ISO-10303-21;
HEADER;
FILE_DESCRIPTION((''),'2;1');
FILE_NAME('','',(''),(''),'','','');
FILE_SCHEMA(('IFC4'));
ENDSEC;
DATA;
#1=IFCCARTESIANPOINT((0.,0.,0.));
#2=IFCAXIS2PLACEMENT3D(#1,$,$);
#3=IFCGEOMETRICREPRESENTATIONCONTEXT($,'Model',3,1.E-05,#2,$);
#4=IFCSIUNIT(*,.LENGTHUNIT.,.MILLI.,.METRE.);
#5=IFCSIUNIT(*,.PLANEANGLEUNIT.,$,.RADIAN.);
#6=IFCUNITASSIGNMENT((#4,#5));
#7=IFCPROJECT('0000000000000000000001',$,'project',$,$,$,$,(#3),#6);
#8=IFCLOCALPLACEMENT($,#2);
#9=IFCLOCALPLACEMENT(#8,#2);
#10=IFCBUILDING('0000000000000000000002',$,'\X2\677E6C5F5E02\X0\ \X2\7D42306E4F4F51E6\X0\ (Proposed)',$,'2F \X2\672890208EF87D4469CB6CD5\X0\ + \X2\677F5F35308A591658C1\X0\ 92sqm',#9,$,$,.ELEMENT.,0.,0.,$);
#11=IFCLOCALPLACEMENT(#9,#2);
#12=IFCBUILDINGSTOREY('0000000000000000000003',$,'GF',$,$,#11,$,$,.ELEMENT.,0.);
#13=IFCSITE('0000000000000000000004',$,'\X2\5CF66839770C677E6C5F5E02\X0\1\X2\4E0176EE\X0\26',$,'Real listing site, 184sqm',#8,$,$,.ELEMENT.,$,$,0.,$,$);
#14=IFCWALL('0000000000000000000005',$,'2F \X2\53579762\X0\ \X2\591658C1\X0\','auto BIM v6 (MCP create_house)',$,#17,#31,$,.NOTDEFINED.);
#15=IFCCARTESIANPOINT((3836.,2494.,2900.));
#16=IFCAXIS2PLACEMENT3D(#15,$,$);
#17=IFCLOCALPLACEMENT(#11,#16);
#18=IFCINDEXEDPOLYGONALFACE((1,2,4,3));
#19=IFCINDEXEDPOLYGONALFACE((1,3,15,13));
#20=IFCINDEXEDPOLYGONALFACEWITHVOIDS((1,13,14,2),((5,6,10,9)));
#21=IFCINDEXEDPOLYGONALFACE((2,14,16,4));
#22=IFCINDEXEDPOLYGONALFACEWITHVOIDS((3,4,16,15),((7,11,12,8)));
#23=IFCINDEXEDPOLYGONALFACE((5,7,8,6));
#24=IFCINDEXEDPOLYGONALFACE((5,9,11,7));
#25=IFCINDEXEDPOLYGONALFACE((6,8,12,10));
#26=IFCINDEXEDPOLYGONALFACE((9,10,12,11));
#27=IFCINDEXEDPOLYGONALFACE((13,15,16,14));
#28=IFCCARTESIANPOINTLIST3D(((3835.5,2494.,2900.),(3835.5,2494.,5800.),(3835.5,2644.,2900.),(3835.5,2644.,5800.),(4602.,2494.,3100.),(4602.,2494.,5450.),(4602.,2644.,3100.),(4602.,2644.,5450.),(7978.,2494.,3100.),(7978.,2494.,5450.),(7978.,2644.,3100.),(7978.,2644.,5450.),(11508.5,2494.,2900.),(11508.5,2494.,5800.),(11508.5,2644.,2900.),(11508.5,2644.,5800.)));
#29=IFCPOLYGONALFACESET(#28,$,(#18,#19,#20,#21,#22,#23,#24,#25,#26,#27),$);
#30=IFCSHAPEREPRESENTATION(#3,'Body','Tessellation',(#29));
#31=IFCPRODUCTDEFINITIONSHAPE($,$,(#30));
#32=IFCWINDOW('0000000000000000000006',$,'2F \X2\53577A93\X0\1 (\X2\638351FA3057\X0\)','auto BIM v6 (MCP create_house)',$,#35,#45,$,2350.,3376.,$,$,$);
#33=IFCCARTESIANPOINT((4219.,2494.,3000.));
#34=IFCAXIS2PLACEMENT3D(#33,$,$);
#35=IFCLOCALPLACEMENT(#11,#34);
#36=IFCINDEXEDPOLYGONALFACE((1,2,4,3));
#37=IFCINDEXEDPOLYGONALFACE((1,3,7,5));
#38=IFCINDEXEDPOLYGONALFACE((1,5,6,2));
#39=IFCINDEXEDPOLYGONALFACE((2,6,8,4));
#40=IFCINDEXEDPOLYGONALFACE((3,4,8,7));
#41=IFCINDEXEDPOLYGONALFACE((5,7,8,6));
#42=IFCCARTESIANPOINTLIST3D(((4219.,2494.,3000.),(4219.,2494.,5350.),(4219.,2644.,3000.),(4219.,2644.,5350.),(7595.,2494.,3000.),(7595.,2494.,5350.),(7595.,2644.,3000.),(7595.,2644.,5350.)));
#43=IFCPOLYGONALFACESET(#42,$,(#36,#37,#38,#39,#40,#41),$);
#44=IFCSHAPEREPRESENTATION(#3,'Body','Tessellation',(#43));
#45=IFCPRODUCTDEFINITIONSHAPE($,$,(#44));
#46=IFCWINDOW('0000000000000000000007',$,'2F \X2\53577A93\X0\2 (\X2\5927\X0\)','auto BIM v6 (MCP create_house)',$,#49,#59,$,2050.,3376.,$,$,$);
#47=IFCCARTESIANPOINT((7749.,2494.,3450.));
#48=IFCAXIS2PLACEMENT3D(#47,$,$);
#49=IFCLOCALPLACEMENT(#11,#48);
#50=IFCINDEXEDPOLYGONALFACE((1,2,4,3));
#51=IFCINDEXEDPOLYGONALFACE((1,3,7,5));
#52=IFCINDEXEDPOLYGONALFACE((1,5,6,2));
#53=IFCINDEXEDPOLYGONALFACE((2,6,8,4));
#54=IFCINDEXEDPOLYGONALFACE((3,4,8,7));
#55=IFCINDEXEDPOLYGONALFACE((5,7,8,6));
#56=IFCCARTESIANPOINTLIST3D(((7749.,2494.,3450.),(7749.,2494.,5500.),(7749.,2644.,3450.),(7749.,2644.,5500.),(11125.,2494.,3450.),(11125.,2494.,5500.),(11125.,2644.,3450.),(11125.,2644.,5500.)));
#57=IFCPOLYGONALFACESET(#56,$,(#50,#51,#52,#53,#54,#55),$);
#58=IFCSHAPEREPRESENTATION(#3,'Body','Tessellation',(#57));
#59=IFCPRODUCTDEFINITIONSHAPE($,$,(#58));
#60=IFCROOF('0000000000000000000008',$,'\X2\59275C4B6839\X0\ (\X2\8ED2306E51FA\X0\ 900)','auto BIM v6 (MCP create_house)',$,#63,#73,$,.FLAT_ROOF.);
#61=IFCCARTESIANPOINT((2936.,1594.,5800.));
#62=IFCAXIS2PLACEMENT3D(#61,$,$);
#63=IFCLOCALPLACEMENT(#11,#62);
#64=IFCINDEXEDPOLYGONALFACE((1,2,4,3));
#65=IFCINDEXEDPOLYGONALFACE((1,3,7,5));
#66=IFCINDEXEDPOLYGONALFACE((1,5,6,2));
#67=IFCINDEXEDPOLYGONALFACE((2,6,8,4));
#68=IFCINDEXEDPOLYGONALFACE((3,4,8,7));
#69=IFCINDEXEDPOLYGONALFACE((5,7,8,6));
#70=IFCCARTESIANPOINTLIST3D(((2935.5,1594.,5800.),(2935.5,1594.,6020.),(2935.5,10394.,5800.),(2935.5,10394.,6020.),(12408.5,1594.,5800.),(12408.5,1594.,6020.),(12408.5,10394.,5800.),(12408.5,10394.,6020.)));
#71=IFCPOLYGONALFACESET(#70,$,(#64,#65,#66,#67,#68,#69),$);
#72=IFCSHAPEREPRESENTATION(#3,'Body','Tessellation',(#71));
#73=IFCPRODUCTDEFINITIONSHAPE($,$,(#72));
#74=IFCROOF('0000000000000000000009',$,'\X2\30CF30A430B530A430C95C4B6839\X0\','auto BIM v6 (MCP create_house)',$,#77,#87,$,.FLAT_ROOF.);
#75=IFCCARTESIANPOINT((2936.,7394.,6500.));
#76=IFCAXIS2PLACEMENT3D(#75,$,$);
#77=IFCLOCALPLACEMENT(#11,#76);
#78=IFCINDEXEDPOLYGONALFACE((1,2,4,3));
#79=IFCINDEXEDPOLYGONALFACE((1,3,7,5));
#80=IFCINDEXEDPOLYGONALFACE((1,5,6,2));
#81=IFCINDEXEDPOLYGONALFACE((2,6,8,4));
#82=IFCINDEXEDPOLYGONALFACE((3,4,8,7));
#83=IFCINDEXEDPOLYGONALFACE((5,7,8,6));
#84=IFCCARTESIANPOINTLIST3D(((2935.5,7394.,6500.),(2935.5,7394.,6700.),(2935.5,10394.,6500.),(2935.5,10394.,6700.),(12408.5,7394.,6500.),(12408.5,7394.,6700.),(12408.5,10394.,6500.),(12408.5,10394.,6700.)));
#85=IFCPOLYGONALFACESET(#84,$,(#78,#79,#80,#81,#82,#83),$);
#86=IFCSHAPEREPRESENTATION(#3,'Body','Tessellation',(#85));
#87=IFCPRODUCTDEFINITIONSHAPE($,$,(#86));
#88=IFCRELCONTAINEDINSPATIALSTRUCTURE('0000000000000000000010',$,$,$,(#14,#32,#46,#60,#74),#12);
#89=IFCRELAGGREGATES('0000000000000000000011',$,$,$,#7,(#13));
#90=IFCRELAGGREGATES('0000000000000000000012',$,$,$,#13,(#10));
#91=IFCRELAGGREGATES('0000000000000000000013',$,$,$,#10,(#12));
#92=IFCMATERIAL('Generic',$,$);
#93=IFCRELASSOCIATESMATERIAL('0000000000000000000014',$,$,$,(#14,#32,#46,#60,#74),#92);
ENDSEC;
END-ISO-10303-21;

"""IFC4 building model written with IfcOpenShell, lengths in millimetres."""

from ifc_helpers import new_model, si_unit, frame, frame_2d, origin, place, context, project, spatial, rectangle, extrude, material, element, fill, save


model = new_model("IFC4")

# Units and contexts
model_context = context("Model", 3, precision=1e-05, world=origin())
ifc_project = project(units=[si_unit("LENGTHUNIT", "METRE", prefix="MILLI"), si_unit("PLANEANGLEUNIT", "RADIAN")], contexts=[model_context])

# Site, building, storey
site_placement = place(None, origin())
site = spatial("IfcSite", under=ifc_project, at=site_placement, Name="島根県松江市1丁目26", ObjectType="Real listing site, 184sqm", CompositionType="ELEMENT", RefElevation=0.0)
building_placement = place(site_placement, origin())
building = spatial("IfcBuilding", under=site, at=building_placement, Name="松江市 終の住処 (Proposed)", ObjectType="2F 木造軸組構法 + 板張り外壁 92sqm", CompositionType="ELEMENT", ElevationOfRefHeight=0.0, ElevationOfTerrain=0.0)
storey_placement = place(building_placement, origin())
storey = spatial("IfcBuildingStorey", under=building, at=storey_placement, Name="GF", CompositionType="ELEMENT", Elevation=0.0)

# Shared definitions
ifc_material = material(Name="Generic")

# Wall, openings, windows
wall_1_placement = place(storey_placement, frame((3836.0, 2494.0, 2900.0)))
wall_1 = element("IfcWall", 1, at=wall_1_placement, inside=storey, material=ifc_material, Name="2F 南面 外壁", Description="auto BIM v6 (MCP create_house)", PredefinedType="NOTDEFINED", context=model_context, shape_type="SweptSolid", body=[
    extrude(rectangle(XDim=7673.0, YDim=150.0, at=frame_2d((3836.0, 75.0))), frame((3836.0, 2494.0, 2900.0)), (0.0, 0.0, 1.0), 2900.0),
])
opening_1_placement = place(storey_placement, frame((4219.0, 2494.0, 3000.0)))
opening_1 = element("IfcOpeningElement", 2, at=opening_1_placement, cuts=wall_1, PredefinedType="NOTDEFINED", context=model_context, shape_type="SweptSolid", body=[
    extrude(rectangle(XDim=3376.0, YDim=150.0, at=frame_2d((1688.0, 75.0))), frame((4219.0, 2494.0, 3000.0)), (0.0, 0.0, 1.0), 2350.0),
])
opening_2_placement = place(storey_placement, frame((7749.0, 2494.0, 3450.0)))
opening_2 = element("IfcOpeningElement", 3, at=opening_2_placement, cuts=wall_1, PredefinedType="NOTDEFINED", context=model_context, shape_type="SweptSolid", body=[
    extrude(rectangle(XDim=3376.0, YDim=150.0, at=frame_2d((1688.0, 75.0))), frame((7749.0, 2494.0, 3450.0)), (0.0, 0.0, 1.0), 2050.0),
])
window_1_placement = place(storey_placement, frame((4219.0, 2494.0, 3000.0)))
window_1 = element("IfcWindow", 4, at=window_1_placement, inside=storey, material=ifc_material, Name="2F 南窓1 (掃出し)", Description="auto BIM v6 (MCP create_house)", OverallHeight=2350.0, OverallWidth=3376.0, context=model_context, shape_type="SweptSolid", body=[
    extrude(rectangle(XDim=3376.0, YDim=150.0, at=frame_2d((1688.0, 75.0))), frame((4219.0, 2494.0, 3000.0)), (0.0, 0.0, 1.0), 2350.0),
])
fill(opening_1, window_1)
window_2_placement = place(storey_placement, frame((7749.0, 2494.0, 3450.0)))
window_2 = element("IfcWindow", 5, at=window_2_placement, inside=storey, material=ifc_material, Name="2F 南窓2 (大)", Description="auto BIM v6 (MCP create_house)", OverallHeight=2050.0, OverallWidth=3376.0, context=model_context, shape_type="SweptSolid", body=[
    extrude(rectangle(XDim=3376.0, YDim=150.0, at=frame_2d((1688.0, 75.0))), frame((7749.0, 2494.0, 3450.0)), (0.0, 0.0, 1.0), 2050.0),
])
fill(opening_2, window_2)

# Roofs
roof_1_placement = place(storey_placement, frame((2936.0, 1594.0, 5800.0)))
element("IfcRoof", 6, at=roof_1_placement, inside=storey, material=ifc_material, Name="大屋根 (軒の出 900)", Description="auto BIM v6 (MCP create_house)", PredefinedType="FLAT_ROOF", context=model_context, shape_type="SweptSolid", body=[
    extrude(rectangle(XDim=9473.0, YDim=8800.0, at=frame_2d((4736.0, 4400.0))), frame((2936.0, 1594.0, 5800.0)), (0.0, 0.0, 1.0), 220.0),
])
roof_2_placement = place(storey_placement, frame((2936.0, 7394.0, 6500.0)))
element("IfcRoof", 7, at=roof_2_placement, inside=storey, material=ifc_material, Name="ハイサイド屋根", Description="auto BIM v6 (MCP create_house)", PredefinedType="FLAT_ROOF", context=model_context, shape_type="SweptSolid", body=[
    extrude(rectangle(XDim=9473.0, YDim=3000.0, at=frame_2d((4736.0, 1500.0))), frame((2936.0, 7394.0, 6500.0)), (0.0, 0.0, 1.0), 200.0),
])

save(model, "model.ifc")
